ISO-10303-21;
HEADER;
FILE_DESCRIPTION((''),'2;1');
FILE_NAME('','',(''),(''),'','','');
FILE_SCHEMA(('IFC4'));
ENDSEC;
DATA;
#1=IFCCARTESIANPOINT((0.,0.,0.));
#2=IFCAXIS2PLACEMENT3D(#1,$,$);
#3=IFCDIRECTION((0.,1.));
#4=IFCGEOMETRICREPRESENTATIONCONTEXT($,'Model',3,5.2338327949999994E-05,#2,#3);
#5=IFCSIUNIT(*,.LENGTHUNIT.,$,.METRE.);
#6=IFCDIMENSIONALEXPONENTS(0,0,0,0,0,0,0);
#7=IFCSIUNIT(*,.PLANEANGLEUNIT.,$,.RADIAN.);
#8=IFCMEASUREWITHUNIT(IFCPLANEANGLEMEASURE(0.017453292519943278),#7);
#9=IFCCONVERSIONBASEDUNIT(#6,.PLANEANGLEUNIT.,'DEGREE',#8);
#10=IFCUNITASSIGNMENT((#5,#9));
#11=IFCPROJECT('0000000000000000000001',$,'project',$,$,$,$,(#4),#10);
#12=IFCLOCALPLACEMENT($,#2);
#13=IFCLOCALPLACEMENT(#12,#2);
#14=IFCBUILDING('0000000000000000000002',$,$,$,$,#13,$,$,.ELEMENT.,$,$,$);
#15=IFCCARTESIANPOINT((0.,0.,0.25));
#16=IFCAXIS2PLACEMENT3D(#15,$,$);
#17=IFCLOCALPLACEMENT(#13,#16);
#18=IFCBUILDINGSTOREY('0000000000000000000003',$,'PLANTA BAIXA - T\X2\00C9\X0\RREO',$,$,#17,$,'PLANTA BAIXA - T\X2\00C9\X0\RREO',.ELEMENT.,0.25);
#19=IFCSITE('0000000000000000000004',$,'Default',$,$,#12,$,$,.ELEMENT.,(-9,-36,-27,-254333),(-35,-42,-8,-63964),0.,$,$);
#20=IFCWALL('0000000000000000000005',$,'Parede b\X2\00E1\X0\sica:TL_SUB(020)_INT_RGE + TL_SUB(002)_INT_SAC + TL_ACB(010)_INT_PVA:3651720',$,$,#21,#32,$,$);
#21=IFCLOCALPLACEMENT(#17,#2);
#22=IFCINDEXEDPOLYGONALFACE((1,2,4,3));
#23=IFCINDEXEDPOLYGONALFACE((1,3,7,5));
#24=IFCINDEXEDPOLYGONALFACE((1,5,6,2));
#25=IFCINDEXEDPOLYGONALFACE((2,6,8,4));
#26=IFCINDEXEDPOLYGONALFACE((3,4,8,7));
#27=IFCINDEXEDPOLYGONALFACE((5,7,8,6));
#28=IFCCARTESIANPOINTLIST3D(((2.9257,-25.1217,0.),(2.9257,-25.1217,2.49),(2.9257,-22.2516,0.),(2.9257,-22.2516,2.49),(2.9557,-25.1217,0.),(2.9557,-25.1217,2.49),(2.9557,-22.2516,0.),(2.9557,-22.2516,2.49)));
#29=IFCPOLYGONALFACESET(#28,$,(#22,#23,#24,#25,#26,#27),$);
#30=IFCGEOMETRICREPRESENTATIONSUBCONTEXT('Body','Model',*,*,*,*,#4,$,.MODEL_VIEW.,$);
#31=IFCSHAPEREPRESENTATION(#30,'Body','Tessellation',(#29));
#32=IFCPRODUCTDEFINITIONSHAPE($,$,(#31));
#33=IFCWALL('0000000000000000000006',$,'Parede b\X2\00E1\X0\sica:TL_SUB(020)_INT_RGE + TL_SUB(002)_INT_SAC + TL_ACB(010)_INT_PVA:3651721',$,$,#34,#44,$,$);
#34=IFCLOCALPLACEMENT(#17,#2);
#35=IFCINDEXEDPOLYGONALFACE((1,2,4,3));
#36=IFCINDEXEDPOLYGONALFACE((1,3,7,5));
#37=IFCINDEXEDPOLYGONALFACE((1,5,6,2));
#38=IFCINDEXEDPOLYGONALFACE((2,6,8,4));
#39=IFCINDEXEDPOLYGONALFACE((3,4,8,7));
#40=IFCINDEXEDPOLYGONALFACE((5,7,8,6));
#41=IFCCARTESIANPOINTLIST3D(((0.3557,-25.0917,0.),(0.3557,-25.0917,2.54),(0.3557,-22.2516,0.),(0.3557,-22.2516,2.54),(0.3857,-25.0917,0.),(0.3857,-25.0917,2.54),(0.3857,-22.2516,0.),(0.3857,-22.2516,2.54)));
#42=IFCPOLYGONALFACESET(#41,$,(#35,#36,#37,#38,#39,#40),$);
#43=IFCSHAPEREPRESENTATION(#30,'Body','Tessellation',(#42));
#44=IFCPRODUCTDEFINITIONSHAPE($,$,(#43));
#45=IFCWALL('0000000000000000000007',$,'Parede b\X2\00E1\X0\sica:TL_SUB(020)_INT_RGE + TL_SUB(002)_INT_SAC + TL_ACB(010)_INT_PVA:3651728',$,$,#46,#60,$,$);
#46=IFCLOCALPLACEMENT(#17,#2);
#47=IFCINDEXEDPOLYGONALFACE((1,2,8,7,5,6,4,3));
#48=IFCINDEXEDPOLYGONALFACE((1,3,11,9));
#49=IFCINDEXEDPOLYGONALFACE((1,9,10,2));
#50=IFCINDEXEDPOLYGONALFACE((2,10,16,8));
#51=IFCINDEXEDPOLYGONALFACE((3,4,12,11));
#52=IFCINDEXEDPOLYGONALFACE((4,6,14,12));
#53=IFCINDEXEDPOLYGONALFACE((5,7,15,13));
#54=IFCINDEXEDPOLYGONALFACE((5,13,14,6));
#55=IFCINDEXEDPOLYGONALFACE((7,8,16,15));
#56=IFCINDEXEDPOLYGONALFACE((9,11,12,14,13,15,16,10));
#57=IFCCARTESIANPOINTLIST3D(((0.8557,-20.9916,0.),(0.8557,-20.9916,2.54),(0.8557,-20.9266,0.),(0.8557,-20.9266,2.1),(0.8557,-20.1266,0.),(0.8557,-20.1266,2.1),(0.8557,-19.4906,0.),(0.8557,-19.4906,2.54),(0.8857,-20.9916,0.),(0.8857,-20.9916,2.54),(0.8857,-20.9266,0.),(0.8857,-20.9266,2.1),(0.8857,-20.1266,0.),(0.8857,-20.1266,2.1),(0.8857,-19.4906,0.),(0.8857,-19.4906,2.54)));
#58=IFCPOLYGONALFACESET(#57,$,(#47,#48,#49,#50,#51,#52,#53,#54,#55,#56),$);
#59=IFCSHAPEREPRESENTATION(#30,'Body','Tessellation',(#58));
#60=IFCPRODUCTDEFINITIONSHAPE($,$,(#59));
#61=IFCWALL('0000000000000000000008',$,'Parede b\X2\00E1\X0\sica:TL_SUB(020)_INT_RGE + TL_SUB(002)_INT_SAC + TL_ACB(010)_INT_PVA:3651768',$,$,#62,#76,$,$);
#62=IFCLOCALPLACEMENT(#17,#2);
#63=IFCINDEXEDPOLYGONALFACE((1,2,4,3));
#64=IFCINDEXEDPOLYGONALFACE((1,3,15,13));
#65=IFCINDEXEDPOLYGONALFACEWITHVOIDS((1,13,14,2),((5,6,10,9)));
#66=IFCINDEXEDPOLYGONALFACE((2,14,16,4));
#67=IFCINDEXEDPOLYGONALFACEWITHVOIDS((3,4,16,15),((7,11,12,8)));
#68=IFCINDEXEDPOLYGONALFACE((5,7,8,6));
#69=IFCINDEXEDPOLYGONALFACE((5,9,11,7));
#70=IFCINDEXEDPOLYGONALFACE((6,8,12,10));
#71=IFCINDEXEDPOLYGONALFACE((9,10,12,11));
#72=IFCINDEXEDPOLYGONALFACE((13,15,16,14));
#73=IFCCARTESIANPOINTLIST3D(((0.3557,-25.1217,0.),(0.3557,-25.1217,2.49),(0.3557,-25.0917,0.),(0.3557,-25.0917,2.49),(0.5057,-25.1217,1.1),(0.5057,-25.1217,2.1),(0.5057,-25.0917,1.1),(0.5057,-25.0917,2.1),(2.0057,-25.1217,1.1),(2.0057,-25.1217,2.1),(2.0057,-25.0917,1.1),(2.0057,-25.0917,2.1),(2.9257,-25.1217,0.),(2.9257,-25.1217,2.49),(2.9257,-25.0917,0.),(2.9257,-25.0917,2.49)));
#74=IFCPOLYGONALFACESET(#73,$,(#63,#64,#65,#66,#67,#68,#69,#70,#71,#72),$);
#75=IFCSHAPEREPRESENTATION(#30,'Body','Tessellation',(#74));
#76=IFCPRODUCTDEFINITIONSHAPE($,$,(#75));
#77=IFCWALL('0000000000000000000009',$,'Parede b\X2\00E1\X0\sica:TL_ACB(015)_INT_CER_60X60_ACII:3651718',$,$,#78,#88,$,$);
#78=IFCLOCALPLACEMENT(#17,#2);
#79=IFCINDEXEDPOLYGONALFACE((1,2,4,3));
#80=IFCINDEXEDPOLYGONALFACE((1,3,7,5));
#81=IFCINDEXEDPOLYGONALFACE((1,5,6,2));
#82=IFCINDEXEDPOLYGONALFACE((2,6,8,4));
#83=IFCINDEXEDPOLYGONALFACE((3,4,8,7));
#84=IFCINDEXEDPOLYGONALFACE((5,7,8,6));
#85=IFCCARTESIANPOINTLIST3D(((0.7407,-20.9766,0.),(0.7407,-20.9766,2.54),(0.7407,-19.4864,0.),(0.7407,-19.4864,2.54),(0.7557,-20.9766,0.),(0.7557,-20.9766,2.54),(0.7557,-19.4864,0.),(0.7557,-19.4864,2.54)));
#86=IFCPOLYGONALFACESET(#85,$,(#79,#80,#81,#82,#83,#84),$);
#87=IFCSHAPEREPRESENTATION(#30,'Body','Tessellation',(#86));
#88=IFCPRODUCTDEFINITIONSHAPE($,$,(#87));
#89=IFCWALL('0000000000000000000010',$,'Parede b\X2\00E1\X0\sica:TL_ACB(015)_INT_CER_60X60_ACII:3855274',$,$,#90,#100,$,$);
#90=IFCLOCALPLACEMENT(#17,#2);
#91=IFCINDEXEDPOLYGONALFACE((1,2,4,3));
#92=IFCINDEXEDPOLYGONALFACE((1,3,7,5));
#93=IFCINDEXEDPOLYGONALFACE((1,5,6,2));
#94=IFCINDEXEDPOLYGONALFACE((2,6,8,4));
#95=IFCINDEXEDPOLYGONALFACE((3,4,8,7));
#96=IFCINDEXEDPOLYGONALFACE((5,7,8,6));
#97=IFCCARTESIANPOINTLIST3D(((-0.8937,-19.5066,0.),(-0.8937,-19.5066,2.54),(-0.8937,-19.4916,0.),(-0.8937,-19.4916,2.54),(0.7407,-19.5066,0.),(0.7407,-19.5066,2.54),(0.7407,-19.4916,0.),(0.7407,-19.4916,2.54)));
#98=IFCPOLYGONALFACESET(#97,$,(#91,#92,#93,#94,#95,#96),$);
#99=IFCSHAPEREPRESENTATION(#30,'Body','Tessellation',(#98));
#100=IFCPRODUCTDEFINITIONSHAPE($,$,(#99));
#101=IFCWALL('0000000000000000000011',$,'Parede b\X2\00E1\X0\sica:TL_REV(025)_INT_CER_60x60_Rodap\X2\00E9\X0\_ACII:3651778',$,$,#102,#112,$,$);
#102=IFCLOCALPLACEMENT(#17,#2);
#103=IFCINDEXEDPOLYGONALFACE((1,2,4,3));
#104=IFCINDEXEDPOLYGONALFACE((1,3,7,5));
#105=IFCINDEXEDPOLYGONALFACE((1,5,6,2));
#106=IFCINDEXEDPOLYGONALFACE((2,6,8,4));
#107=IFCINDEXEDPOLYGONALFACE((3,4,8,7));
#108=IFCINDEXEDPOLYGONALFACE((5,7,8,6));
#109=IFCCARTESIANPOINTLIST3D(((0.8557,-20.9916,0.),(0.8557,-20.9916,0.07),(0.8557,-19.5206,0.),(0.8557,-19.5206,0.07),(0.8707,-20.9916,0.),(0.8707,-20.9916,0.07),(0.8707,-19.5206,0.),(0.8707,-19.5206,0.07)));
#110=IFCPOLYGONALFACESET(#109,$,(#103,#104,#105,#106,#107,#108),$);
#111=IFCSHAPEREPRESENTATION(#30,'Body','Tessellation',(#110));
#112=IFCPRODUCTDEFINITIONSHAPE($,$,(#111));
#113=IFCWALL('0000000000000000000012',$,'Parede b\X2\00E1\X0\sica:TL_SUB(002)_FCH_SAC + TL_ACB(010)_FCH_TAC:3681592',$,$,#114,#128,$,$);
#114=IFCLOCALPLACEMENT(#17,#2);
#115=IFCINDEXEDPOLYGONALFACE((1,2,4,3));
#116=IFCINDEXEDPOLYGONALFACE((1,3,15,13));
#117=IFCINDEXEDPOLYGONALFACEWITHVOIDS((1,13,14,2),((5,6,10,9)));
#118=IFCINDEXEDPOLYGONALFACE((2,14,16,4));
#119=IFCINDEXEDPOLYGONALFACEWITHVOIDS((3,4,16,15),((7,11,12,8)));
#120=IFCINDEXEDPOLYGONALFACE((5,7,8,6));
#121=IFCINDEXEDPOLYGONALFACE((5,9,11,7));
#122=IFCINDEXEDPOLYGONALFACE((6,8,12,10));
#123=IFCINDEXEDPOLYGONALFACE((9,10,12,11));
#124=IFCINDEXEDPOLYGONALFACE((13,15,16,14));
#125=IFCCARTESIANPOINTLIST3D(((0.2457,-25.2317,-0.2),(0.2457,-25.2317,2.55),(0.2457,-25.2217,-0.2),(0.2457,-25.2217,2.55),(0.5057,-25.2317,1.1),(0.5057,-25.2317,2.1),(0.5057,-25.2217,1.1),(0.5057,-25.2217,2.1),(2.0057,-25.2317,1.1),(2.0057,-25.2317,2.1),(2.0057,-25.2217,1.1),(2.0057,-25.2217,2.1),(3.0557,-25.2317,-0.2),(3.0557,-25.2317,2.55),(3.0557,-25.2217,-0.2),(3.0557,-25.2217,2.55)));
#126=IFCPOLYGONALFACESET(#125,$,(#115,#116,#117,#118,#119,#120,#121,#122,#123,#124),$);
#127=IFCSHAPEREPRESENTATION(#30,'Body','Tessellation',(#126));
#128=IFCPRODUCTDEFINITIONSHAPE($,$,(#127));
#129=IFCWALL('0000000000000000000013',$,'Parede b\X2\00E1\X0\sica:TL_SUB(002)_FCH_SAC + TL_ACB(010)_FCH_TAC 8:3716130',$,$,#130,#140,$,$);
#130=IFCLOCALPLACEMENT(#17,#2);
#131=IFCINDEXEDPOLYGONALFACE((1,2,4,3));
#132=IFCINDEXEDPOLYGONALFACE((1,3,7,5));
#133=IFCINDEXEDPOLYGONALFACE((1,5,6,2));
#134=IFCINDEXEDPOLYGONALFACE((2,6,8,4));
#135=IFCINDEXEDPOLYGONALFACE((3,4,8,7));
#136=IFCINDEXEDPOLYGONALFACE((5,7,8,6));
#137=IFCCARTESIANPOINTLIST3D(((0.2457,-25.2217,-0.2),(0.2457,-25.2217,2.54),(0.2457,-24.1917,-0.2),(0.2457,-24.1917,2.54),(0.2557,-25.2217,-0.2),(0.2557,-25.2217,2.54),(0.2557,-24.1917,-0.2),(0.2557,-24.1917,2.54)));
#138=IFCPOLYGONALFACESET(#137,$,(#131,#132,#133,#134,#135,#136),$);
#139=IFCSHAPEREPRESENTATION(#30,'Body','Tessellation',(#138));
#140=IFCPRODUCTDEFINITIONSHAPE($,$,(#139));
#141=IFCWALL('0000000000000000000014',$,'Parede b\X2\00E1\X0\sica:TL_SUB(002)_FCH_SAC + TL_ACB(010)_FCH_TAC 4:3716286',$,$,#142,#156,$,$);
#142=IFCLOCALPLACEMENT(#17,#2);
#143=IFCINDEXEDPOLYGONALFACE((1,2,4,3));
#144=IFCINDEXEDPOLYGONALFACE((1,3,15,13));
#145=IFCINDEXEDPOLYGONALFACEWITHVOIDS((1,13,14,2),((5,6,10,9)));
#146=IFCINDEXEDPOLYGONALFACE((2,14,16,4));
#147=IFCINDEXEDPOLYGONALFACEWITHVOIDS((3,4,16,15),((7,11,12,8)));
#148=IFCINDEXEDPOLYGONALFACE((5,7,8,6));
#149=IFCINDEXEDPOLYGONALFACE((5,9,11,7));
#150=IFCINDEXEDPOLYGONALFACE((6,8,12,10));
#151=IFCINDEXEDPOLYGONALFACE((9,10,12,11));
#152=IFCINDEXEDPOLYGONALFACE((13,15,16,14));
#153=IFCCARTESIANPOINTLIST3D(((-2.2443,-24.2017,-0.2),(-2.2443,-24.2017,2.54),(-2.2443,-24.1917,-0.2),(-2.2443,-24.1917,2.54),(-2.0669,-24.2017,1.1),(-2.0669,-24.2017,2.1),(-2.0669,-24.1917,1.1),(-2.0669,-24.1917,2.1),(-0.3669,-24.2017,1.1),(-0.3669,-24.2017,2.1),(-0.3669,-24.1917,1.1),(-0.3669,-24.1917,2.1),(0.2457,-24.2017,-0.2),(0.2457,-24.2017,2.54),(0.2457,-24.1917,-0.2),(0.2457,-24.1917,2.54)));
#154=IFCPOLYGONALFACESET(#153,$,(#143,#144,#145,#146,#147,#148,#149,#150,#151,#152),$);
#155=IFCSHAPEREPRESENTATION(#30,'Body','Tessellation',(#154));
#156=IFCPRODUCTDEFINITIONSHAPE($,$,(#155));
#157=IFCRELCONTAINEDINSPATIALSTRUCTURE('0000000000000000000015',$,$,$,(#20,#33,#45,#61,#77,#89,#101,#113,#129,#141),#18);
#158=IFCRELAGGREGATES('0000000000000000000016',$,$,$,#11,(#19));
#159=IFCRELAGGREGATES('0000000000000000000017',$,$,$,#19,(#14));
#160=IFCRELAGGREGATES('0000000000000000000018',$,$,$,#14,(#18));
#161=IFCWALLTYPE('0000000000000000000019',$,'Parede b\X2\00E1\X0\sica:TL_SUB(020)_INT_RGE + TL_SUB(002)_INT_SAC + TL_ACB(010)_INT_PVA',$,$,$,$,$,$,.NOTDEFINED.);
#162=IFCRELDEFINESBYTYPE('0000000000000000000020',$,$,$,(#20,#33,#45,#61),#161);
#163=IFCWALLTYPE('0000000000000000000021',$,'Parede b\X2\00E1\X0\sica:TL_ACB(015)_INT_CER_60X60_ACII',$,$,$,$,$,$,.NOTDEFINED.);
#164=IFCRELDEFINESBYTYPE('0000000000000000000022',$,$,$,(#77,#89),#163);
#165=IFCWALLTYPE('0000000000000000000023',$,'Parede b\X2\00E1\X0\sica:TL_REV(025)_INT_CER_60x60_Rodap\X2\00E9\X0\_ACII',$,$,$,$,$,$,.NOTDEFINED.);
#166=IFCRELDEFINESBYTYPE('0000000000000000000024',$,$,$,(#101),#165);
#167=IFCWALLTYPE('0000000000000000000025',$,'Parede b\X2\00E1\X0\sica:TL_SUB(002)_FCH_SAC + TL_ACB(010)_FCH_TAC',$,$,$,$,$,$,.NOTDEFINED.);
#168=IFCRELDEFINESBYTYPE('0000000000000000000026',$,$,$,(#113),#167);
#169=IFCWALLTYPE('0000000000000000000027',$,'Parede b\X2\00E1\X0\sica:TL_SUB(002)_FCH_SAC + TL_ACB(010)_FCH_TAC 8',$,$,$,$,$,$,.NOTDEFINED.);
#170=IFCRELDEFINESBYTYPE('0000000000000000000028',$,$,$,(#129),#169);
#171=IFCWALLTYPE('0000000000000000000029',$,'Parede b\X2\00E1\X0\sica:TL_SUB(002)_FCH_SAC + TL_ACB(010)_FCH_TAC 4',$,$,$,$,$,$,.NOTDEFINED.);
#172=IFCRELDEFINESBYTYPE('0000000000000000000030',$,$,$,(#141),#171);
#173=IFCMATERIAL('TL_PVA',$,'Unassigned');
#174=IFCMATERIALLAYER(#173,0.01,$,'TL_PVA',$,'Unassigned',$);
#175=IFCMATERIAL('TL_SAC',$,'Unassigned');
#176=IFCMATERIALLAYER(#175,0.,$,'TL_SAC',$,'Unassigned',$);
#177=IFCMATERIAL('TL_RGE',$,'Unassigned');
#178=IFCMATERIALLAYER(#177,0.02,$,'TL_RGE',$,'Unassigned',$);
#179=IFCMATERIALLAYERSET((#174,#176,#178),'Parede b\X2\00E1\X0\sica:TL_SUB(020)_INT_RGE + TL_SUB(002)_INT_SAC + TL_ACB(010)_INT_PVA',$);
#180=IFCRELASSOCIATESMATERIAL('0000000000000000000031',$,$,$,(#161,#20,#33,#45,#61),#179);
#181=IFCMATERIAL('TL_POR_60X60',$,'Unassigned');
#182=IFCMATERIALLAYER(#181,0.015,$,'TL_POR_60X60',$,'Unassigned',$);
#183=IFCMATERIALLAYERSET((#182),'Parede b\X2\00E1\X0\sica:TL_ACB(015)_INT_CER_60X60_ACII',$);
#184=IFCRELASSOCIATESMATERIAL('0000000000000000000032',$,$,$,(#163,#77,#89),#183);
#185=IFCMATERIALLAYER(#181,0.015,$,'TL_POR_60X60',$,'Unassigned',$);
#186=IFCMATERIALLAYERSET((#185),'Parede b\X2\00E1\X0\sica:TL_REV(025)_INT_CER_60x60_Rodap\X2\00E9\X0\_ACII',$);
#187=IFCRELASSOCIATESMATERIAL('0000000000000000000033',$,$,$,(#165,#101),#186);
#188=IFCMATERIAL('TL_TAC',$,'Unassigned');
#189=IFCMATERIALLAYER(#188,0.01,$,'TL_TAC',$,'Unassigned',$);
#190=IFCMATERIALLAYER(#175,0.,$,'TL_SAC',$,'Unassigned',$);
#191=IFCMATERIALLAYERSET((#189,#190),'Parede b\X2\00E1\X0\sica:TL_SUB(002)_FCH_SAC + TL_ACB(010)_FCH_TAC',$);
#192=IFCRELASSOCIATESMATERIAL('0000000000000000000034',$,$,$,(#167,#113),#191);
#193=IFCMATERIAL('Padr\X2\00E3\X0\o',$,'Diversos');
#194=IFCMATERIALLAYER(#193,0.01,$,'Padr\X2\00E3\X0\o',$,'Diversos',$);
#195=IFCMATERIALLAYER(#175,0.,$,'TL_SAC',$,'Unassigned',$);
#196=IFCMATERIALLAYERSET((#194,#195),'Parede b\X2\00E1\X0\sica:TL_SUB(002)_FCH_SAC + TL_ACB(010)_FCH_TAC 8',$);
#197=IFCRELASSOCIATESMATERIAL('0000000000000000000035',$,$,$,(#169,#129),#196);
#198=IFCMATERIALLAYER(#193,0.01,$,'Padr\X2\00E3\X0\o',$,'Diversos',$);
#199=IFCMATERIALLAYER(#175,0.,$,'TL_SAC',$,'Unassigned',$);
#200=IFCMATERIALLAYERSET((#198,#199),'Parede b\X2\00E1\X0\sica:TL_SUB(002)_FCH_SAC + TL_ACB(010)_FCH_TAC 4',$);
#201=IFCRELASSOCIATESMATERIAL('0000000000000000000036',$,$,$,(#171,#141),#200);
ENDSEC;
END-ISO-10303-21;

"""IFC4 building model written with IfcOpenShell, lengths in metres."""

from ifc_helpers import new_model, entity, si_unit, converted_unit, direction, frame, frame_2d, origin, place, context, subcontext, project, spatial, rectangle, extrude, material, layer, layer_set, layer_usage, type_object, element, save


model = new_model("IFC4")

# Units and contexts
model_context = context("Model", 3, precision=5.2338327949999994e-05, world=origin(), true_north=direction((0.0, 1.0)))
body_context = subcontext(model_context, "Body", "Model", "MODEL_VIEW")
ifc_project = project(units=[si_unit("LENGTHUNIT", "METRE"), converted_unit("PLANEANGLEUNIT", "DEGREE", entity("IfcPlaneAngleMeasure", 0.017453292519943278), si_unit("PLANEANGLEUNIT", "RADIAN"), dimensions=[0, 0, 0, 0, 0, 0, 0])], contexts=[model_context])

# Site, building, storey
site_placement = place(None, frame((0.0, 0.0, 0.0)))
site = spatial("IfcSite", under=ifc_project, at=site_placement, Name="Default", CompositionType="ELEMENT", RefLatitude=(-9, -36, -27, -254333), RefLongitude=(-35, -42, -8, -63964), RefElevation=0.0)
building_placement = place(site_placement, origin())
building = spatial("IfcBuilding", under=site, at=building_placement, CompositionType="ELEMENT")
storey_placement = place(building_placement, frame((0.0, 0.0, 0.25)))
storey = spatial("IfcBuildingStorey", under=building, at=storey_placement, Name="PLANTA BAIXA - TÉRREO", LongName="PLANTA BAIXA - TÉRREO", CompositionType="ELEMENT", Elevation=0.25)

# Shared definitions
ifc_material_1 = material(Name="TL_PVA", Category="Unassigned")
ifc_layer_1 = layer(ifc_material_1, 0.01, Name="TL_PVA", Category="Unassigned")
ifc_material_2 = material(Name="TL_SAC", Category="Unassigned")
ifc_layer_2 = layer(ifc_material_2, 0.0, Name="TL_SAC", Category="Unassigned")
ifc_material_3 = material(Name="TL_RGE", Category="Unassigned")
ifc_layer_3 = layer(ifc_material_3, 0.02, Name="TL_RGE", Category="Unassigned")
ifc_layer_set_1 = layer_set([ifc_layer_1, ifc_layer_2, ifc_layer_3], Name="Parede básica:TL_SUB(020)_INT_RGE + TL_SUB(002)_INT_SAC + TL_ACB(010)_INT_PVA")
wall_type_1 = type_object("IfcWallType", Name="Parede básica:TL_SUB(020)_INT_RGE + TL_SUB(002)_INT_SAC + TL_ACB(010)_INT_PVA", PredefinedType="NOTDEFINED", material=ifc_layer_set_1)

# Walls
ifc_layer_usage_1 = layer_usage(ifc_layer_set_1, "AXIS2", "POSITIVE", -0.015)
wall_1_placement = place(storey_placement, frame((2.9407, -22.2516, 0.0), z_axis=(0.0, 0.0, 1.0), x_axis=(0.0, -1.0, 0.0)))
element("IfcWall", 1, at=wall_1_placement, inside=storey, type_object=wall_type_1, material=ifc_layer_usage_1, Name="Parede básica:TL_SUB(020)_INT_RGE + TL_SUB(002)_INT_SAC + TL_ACB(010)_INT_PVA:3651720", context=body_context, shape_type="SweptSolid", body=[
    extrude(rectangle(XDim=2.8701, YDim=0.03, at=frame_2d((1.4351, 0.0), x_axis=(-1.0, 0.0))), origin(), (0.0, 0.0, 1.0), 2.49),
])
ifc_layer_usage_2 = layer_usage(ifc_layer_set_1, "AXIS2", "POSITIVE", -0.015)
wall_2_placement = place(storey_placement, frame((0.3707, -25.0917, 0.0), z_axis=(0.0, 0.0, 1.0), x_axis=(0.0, 1.0, 0.0)))
element("IfcWall", 2, at=wall_2_placement, inside=storey, type_object=wall_type_1, material=ifc_layer_usage_2, Name="Parede básica:TL_SUB(020)_INT_RGE + TL_SUB(002)_INT_SAC + TL_ACB(010)_INT_PVA:3651721", context=body_context, shape_type="SweptSolid", body=[
    extrude(rectangle(XDim=2.8401, YDim=0.03, at=frame_2d((1.4201, 0.0), x_axis=(-1.0, 0.0))), origin(), (0.0, 0.0, 1.0), 2.54),
])

# Walls, openings
ifc_layer_usage_3 = layer_usage(ifc_layer_set_1, "AXIS2", "POSITIVE", -0.015)
wall_3_placement = place(storey_placement, frame((0.8707, -20.9916, 0.0), z_axis=(0.0, 0.0, 1.0), x_axis=(0.0, 1.0, 0.0)))
wall_3 = element("IfcWall", 3, at=wall_3_placement, inside=storey, type_object=wall_type_1, material=ifc_layer_usage_3, Name="Parede básica:TL_SUB(020)_INT_RGE + TL_SUB(002)_INT_SAC + TL_ACB(010)_INT_PVA:3651728", context=body_context, shape_type="SweptSolid", body=[
    extrude(rectangle(XDim=1.501, YDim=0.03, at=frame_2d((0.7505, 0.0), x_axis=(-1.0, 0.0))), origin(), (0.0, 0.0, 1.0), 2.54),
])
opening_1_placement = place(wall_3_placement, frame((0.065, -0.015, 0.0)))
element("IfcOpeningElement", 4, at=opening_1_placement, cuts=wall_3, PredefinedType="OPENING", context=body_context, shape_type="SweptSolid", body=[
    extrude(rectangle(XDim=2.1, YDim=0.8, at=frame_2d((1.05, 0.4), x_axis=(1.0, 0.0))), frame((0.0, 0.0, 0.0), z_axis=(0.0, 1.0, 0.0), x_axis=(0.0, 0.0, 1.0)), (0.0, 0.0, 1.0), 0.03),
])
ifc_layer_usage_4 = layer_usage(ifc_layer_set_1, "AXIS2", "POSITIVE", -0.015)
wall_4_placement = place(storey_placement, frame((2.9257, -25.1067, 0.0), z_axis=(0.0, 0.0, 1.0), x_axis=(-1.0, 0.0, 0.0)))
wall_4 = element("IfcWall", 5, at=wall_4_placement, inside=storey, type_object=wall_type_1, material=ifc_layer_usage_4, Name="Parede básica:TL_SUB(020)_INT_RGE + TL_SUB(002)_INT_SAC + TL_ACB(010)_INT_PVA:3651768", context=body_context, shape_type="SweptSolid", body=[
    extrude(rectangle(XDim=2.57, YDim=0.03, at=frame_2d((1.285, 0.0), x_axis=(-1.0, 0.0))), origin(), (0.0, 0.0, 1.0), 2.49),
])
opening_2_placement = place(wall_4_placement, frame((2.9257, -25.1067, 1.1)))
element("IfcOpeningElement", 6, at=opening_2_placement, cuts=wall_4, PredefinedType="OPENING", context=body_context, shape_type="SweptSolid", body=[
    extrude(rectangle(XDim=1.0, YDim=1.5, at=frame_2d((0.0, 0.0), x_axis=(0.0, 1.0))), frame((-1.2557, 23.5977, 0.5), z_axis=(0.0, 1.0, 0.0), x_axis=(1.0, 0.0, 0.0)), (0.0, 0.0, 1.0), 3.048),
])

# Walls
ifc_material_4 = material(Name="TL_POR_60X60", Category="Unassigned")
ifc_layer_4 = layer(ifc_material_4, 0.015, Name="TL_POR_60X60", Category="Unassigned")
ifc_layer_set_2 = layer_set([ifc_layer_4], Name="Parede básica:TL_ACB(015)_INT_CER_60X60_ACII")
ifc_layer_usage_5 = layer_usage(ifc_layer_set_2, "AXIS2", "POSITIVE", -0.0075)
wall_type_2 = type_object("IfcWallType", Name="Parede básica:TL_ACB(015)_INT_CER_60X60_ACII", PredefinedType="NOTDEFINED", material=ifc_layer_set_2)
wall_5_placement = place(storey_placement, frame((0.7482, -19.4864, 0.0), z_axis=(0.0, 0.0, 1.0), x_axis=(0.0, -1.0, 0.0)))
element("IfcWall", 7, at=wall_5_placement, inside=storey, type_object=wall_type_2, material=ifc_layer_usage_5, Name="Parede básica:TL_ACB(015)_INT_CER_60X60_ACII:3651718", context=body_context, shape_type="SweptSolid", body=[
    extrude(rectangle(XDim=1.4902, YDim=0.015, at=frame_2d((0.7451, 0.0), x_axis=(-1.0, 0.0))), origin(), (0.0, 0.0, 1.0), 2.54),
])
ifc_layer_usage_6 = layer_usage(ifc_layer_set_2, "AXIS2", "NEGATIVE", 0.0075)
wall_6_placement = place(storey_placement, frame((0.7407, -19.4991, 0.0), z_axis=(0.0, 0.0, 1.0), x_axis=(-1.0, 0.0, 0.0)))
element("IfcWall", 8, at=wall_6_placement, inside=storey, type_object=wall_type_2, material=ifc_layer_usage_6, Name="Parede básica:TL_ACB(015)_INT_CER_60X60_ACII:3855274", context=body_context, shape_type="SweptSolid", body=[
    extrude(rectangle(XDim=1.6345, YDim=0.015, at=frame_2d((0.8172, 0.0), x_axis=(-1.0, 0.0))), origin(), (0.0, 0.0, 1.0), 2.54),
])
ifc_layer_5 = layer(ifc_material_4, 0.015, Name="TL_POR_60X60", Category="Unassigned")
ifc_layer_set_3 = layer_set([ifc_layer_5], Name="Parede básica:TL_REV(025)_INT_CER_60x60_Rodapé_ACII")
ifc_layer_usage_7 = layer_usage(ifc_layer_set_3, "AXIS2", "NEGATIVE", 0.0075)
wall_type_3 = type_object("IfcWallType", Name="Parede básica:TL_REV(025)_INT_CER_60x60_Rodapé_ACII", PredefinedType="NOTDEFINED", material=ifc_layer_set_3)
wall_7_placement = place(storey_placement, frame((0.8632, -19.5206, 0.0), z_axis=(0.0, 0.0, 1.0), x_axis=(0.0, -1.0, 0.0)))
element("IfcWall", 9, at=wall_7_placement, inside=storey, type_object=wall_type_3, material=ifc_layer_usage_7, Name="Parede básica:TL_REV(025)_INT_CER_60x60_Rodapé_ACII:3651778", context=body_context, shape_type="SweptSolid", body=[
    extrude(rectangle(XDim=1.471, YDim=0.015, at=frame_2d((0.7355, 0.0), x_axis=(-1.0, 0.0))), origin(), (0.0, 0.0, 1.0), 0.07),
])

# Wall, opening
ifc_material_5 = material(Name="TL_TAC", Category="Unassigned")
ifc_layer_6 = layer(ifc_material_5, 0.01, Name="TL_TAC", Category="Unassigned")
ifc_layer_7 = layer(ifc_material_2, 0.0, Name="TL_SAC", Category="Unassigned")
ifc_layer_set_4 = layer_set([ifc_layer_6, ifc_layer_7], Name="Parede básica:TL_SUB(002)_FCH_SAC + TL_ACB(010)_FCH_TAC")
ifc_layer_usage_8 = layer_usage(ifc_layer_set_4, "AXIS2", "NEGATIVE", 0.005)
wall_type_4 = type_object("IfcWallType", Name="Parede básica:TL_SUB(002)_FCH_SAC + TL_ACB(010)_FCH_TAC", PredefinedType="NOTDEFINED", material=ifc_layer_set_4)
wall_8_placement = place(storey_placement, frame((3.0557, -25.2267, -0.2), z_axis=(0.0, 0.0, 1.0), x_axis=(-1.0, 0.0, 0.0)))
wall_8 = element("IfcWall", 10, at=wall_8_placement, inside=storey, type_object=wall_type_4, material=ifc_layer_usage_8, Name="Parede básica:TL_SUB(002)_FCH_SAC + TL_ACB(010)_FCH_TAC:3681592", context=body_context, shape_type="SweptSolid", body=[
    extrude(rectangle(XDim=2.81, YDim=0.01, at=frame_2d((1.405, 0.0), x_axis=(-1.0, 0.0))), origin(), (0.0, 0.0, 1.0), 2.75),
])
opening_3_placement = place(wall_8_placement, frame((3.0557, -25.2267, 1.3)))
element("IfcOpeningElement", 11, at=opening_3_placement, cuts=wall_8, PredefinedType="OPENING", context=body_context, shape_type="SweptSolid", body=[
    extrude(rectangle(XDim=1.0, YDim=1.5, at=frame_2d((0.0, 0.0), x_axis=(0.0, 1.0))), frame((-1.2557, 23.5977, 0.5), z_axis=(0.0, 1.0, 0.0), x_axis=(1.0, 0.0, 0.0)), (0.0, 0.0, 1.0), 3.048),
])

# Wall
ifc_material_6 = material(Name="Padrão", Category="Diversos")
ifc_layer_8 = layer(ifc_material_6, 0.01, Name="Padrão", Category="Diversos")
ifc_layer_9 = layer(ifc_material_2, 0.0, Name="TL_SAC", Category="Unassigned")
ifc_layer_set_5 = layer_set([ifc_layer_8, ifc_layer_9], Name="Parede básica:TL_SUB(002)_FCH_SAC + TL_ACB(010)_FCH_TAC 8")
ifc_layer_usage_9 = layer_usage(ifc_layer_set_5, "AXIS2", "POSITIVE", -0.005)
wall_type_5 = type_object("IfcWallType", Name="Parede básica:TL_SUB(002)_FCH_SAC + TL_ACB(010)_FCH_TAC 8", PredefinedType="NOTDEFINED", material=ifc_layer_set_5)
wall_9_placement = place(storey_placement, frame((0.2507, -25.2217, -0.2), z_axis=(0.0, 0.0, 1.0), x_axis=(0.0, 1.0, 0.0)))
element("IfcWall", 12, at=wall_9_placement, inside=storey, type_object=wall_type_5, material=ifc_layer_usage_9, Name="Parede básica:TL_SUB(002)_FCH_SAC + TL_ACB(010)_FCH_TAC 8:3716130", context=body_context, shape_type="SweptSolid", body=[
    extrude(rectangle(XDim=1.03, YDim=0.01, at=frame_2d((0.515, 0.0), x_axis=(-1.0, 0.0))), origin(), (0.0, 0.0, 1.0), 2.74),
])

# Wall, opening
ifc_layer_10 = layer(ifc_material_6, 0.01, Name="Padrão", Category="Diversos")
ifc_layer_11 = layer(ifc_material_2, 0.0, Name="TL_SAC", Category="Unassigned")
ifc_layer_set_6 = layer_set([ifc_layer_10, ifc_layer_11], Name="Parede básica:TL_SUB(002)_FCH_SAC + TL_ACB(010)_FCH_TAC 4")
ifc_layer_usage_10 = layer_usage(ifc_layer_set_6, "AXIS2", "POSITIVE", -0.005)
wall_type_6 = type_object("IfcWallType", Name="Parede básica:TL_SUB(002)_FCH_SAC + TL_ACB(010)_FCH_TAC 4", PredefinedType="NOTDEFINED", material=ifc_layer_set_6)
wall_10_placement = place(storey_placement, frame((0.2457, -24.1967, -0.2), z_axis=(0.0, 0.0, 1.0), x_axis=(-1.0, 0.0, 0.0)))
wall_10 = element("IfcWall", 13, at=wall_10_placement, inside=storey, type_object=wall_type_6, material=ifc_layer_usage_10, Name="Parede básica:TL_SUB(002)_FCH_SAC + TL_ACB(010)_FCH_TAC 4:3716286", context=body_context, shape_type="SweptSolid", body=[
    extrude(rectangle(XDim=2.49, YDim=0.01, at=frame_2d((1.245, 0.0), x_axis=(-1.0, 0.0))), origin(), (0.0, 0.0, 1.0), 2.74),
])
opening_4_placement = place(wall_10_placement, frame((0.2457, -24.1967, 1.3)))
element("IfcOpeningElement", 14, at=opening_4_placement, cuts=wall_10, PredefinedType="OPENING", context=body_context, shape_type="SweptSolid", body=[
    extrude(rectangle(XDim=1.0, YDim=1.7, at=frame_2d((0.0, 0.0), x_axis=(0.0, 1.0))), frame((1.2169, 22.5677, 0.5), z_axis=(0.0, 1.0, 0.0), x_axis=(1.0, 0.0, 0.0)), (0.0, 0.0, 1.0), 3.048),
])

save(model, "model.ifc")
